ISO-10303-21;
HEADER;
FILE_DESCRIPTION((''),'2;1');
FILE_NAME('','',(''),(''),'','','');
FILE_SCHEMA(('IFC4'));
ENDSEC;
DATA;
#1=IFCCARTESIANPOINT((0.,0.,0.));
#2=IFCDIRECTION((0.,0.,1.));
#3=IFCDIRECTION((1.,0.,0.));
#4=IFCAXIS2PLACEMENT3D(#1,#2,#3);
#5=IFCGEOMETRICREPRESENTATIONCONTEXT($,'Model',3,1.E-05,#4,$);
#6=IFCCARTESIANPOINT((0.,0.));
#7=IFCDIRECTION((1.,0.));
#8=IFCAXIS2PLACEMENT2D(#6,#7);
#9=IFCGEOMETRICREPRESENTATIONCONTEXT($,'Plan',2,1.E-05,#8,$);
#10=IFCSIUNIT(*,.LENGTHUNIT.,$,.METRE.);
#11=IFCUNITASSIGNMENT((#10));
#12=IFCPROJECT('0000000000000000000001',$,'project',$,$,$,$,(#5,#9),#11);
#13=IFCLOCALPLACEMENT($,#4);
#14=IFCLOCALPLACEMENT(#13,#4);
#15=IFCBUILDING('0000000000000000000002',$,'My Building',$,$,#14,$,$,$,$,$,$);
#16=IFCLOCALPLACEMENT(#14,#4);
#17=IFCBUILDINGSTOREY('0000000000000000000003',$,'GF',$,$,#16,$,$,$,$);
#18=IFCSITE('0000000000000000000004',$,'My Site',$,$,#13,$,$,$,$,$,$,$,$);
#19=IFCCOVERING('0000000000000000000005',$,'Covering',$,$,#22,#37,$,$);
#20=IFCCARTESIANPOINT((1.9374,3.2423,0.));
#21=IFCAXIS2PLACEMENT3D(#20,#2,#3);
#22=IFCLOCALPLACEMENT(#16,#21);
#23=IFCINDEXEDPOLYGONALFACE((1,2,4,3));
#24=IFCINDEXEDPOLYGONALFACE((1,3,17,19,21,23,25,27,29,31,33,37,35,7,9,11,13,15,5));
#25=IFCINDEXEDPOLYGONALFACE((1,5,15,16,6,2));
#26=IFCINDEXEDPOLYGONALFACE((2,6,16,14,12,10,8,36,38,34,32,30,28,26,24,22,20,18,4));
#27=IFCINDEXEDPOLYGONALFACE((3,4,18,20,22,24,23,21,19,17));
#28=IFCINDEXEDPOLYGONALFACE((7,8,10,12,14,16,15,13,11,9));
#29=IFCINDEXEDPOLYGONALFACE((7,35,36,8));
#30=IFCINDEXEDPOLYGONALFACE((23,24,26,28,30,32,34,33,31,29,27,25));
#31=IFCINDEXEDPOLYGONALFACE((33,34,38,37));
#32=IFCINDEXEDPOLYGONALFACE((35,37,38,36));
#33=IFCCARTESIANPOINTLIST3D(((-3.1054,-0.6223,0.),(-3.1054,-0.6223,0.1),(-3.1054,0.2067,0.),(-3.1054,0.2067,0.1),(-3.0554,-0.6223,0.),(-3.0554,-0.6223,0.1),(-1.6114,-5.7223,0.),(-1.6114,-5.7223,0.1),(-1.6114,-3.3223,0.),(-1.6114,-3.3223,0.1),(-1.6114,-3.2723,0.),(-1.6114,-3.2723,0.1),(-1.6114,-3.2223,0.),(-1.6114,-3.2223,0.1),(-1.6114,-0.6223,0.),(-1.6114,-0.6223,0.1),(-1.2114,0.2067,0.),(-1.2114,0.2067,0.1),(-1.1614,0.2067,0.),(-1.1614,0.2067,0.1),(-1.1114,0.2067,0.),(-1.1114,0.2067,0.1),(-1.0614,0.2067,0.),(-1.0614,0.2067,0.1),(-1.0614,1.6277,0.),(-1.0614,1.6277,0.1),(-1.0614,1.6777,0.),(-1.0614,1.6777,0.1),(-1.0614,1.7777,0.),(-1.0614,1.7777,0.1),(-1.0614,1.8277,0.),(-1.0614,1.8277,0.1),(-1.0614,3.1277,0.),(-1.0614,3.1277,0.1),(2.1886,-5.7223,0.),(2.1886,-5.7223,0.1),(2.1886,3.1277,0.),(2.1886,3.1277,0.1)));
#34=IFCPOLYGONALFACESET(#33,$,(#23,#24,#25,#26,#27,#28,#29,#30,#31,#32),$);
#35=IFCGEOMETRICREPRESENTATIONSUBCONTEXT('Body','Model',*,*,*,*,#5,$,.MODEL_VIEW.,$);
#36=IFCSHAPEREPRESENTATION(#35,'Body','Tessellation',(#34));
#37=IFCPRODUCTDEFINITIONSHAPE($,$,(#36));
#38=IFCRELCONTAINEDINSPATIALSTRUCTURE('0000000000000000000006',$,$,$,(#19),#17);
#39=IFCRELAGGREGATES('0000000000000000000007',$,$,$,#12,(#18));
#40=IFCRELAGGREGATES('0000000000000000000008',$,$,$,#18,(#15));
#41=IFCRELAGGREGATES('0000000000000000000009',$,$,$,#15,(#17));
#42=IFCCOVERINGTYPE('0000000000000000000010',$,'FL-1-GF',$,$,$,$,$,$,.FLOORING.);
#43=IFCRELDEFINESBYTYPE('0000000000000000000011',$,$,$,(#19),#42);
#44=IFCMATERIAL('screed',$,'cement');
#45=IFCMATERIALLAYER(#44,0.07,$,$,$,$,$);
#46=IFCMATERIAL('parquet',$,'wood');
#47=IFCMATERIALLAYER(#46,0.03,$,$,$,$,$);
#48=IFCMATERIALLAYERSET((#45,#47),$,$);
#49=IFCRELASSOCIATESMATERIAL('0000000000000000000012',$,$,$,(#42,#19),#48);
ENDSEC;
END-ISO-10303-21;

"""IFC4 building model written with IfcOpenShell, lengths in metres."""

from ifc_helpers import new_model, si_unit, frame, origin_with_axes, origin_2d_with_axis, place, context, subcontext, project, spatial, line, indexed_curve, outline, extrude, material, layer, layer_set, layer_usage, type_object, element, save


model = new_model("IFC4")

# Units and contexts
model_context = context("Model", 3, precision=1e-05, world=origin_with_axes())
plan_context = context("Plan", 2, precision=1e-05, world=origin_2d_with_axis())
body_context_1 = subcontext(model_context, "Body", "Model", "MODEL_VIEW")
ifc_project = project(units=[si_unit("LENGTHUNIT", "METRE")], contexts=[model_context, plan_context])

# Site, building, storey
site_placement = place(None, origin_with_axes())
site = spatial("IfcSite", under=ifc_project, at=site_placement, Name="My Site")
building_placement = place(site_placement, origin_with_axes())
building = spatial("IfcBuilding", under=site, at=building_placement, Name="My Building")
storey_placement = place(building_placement, origin_with_axes())
storey = spatial("IfcBuildingStorey", under=building, at=storey_placement, Name="GF")

# Covering
ifc_material_1 = material(Name="screed", Category="cement")
ifc_layer_1 = layer(ifc_material_1, 0.07)
ifc_material_2 = material(Name="parquet", Category="wood")
ifc_layer_2 = layer(ifc_material_2, 0.03)
ifc_layer_set_1 = layer_set([ifc_layer_1, ifc_layer_2])
ifc_layer_usage_1 = layer_usage(ifc_layer_set_1, "AXIS3", "POSITIVE", 0.0)
covering_type = type_object("IfcCoveringType", Name="FL-1-GF", PredefinedType="FLOORING", material=ifc_layer_set_1)
covering_placement = place(storey_placement, frame((1.9374, 3.2423, 0.0), z_axis=(0.0, 0.0, 1.0), x_axis=(1.0, 0.0, 0.0)))
element("IfcCovering", 1, at=covering_placement, inside=storey, type_object=covering_type, material=ifc_layer_usage_1, Name="Covering", context=body_context_1, shape_type="SweptSolid", body=[
    extrude(outline(indexed_curve([(-1.0614, 3.1277), (2.1886, 3.1277), (2.1886, -5.7223), (-1.6114, -5.7223), (-1.6114, -5.7223), (-1.6114, -3.3223), (-1.6114, -3.2723), (-1.6114, -3.2723), (-1.6114, -3.2223), (-1.6114, -0.6223), (-3.0554, -0.6223), (-3.1054, -0.6223), (-3.1054, 0.2067), (-1.2114, 0.2067), (-1.1614, 0.2067), (-1.1114, 0.2067), (-1.0614, 0.2067), (-1.0614, 1.6277), (-1.0614, 1.6777), (-1.0614, 1.7777), (-1.0614, 1.8277)], segments=[line(1, 2, 3, 4, 5, 6, 7, 8, 9, 10, 11, 12, 13, 14, 15, 16, 17, 18, 19, 20, 21, 1)])), origin_with_axes(), (0.0, 0.0, 1.0), 0.1),
])

save(model, "model.ifc")
